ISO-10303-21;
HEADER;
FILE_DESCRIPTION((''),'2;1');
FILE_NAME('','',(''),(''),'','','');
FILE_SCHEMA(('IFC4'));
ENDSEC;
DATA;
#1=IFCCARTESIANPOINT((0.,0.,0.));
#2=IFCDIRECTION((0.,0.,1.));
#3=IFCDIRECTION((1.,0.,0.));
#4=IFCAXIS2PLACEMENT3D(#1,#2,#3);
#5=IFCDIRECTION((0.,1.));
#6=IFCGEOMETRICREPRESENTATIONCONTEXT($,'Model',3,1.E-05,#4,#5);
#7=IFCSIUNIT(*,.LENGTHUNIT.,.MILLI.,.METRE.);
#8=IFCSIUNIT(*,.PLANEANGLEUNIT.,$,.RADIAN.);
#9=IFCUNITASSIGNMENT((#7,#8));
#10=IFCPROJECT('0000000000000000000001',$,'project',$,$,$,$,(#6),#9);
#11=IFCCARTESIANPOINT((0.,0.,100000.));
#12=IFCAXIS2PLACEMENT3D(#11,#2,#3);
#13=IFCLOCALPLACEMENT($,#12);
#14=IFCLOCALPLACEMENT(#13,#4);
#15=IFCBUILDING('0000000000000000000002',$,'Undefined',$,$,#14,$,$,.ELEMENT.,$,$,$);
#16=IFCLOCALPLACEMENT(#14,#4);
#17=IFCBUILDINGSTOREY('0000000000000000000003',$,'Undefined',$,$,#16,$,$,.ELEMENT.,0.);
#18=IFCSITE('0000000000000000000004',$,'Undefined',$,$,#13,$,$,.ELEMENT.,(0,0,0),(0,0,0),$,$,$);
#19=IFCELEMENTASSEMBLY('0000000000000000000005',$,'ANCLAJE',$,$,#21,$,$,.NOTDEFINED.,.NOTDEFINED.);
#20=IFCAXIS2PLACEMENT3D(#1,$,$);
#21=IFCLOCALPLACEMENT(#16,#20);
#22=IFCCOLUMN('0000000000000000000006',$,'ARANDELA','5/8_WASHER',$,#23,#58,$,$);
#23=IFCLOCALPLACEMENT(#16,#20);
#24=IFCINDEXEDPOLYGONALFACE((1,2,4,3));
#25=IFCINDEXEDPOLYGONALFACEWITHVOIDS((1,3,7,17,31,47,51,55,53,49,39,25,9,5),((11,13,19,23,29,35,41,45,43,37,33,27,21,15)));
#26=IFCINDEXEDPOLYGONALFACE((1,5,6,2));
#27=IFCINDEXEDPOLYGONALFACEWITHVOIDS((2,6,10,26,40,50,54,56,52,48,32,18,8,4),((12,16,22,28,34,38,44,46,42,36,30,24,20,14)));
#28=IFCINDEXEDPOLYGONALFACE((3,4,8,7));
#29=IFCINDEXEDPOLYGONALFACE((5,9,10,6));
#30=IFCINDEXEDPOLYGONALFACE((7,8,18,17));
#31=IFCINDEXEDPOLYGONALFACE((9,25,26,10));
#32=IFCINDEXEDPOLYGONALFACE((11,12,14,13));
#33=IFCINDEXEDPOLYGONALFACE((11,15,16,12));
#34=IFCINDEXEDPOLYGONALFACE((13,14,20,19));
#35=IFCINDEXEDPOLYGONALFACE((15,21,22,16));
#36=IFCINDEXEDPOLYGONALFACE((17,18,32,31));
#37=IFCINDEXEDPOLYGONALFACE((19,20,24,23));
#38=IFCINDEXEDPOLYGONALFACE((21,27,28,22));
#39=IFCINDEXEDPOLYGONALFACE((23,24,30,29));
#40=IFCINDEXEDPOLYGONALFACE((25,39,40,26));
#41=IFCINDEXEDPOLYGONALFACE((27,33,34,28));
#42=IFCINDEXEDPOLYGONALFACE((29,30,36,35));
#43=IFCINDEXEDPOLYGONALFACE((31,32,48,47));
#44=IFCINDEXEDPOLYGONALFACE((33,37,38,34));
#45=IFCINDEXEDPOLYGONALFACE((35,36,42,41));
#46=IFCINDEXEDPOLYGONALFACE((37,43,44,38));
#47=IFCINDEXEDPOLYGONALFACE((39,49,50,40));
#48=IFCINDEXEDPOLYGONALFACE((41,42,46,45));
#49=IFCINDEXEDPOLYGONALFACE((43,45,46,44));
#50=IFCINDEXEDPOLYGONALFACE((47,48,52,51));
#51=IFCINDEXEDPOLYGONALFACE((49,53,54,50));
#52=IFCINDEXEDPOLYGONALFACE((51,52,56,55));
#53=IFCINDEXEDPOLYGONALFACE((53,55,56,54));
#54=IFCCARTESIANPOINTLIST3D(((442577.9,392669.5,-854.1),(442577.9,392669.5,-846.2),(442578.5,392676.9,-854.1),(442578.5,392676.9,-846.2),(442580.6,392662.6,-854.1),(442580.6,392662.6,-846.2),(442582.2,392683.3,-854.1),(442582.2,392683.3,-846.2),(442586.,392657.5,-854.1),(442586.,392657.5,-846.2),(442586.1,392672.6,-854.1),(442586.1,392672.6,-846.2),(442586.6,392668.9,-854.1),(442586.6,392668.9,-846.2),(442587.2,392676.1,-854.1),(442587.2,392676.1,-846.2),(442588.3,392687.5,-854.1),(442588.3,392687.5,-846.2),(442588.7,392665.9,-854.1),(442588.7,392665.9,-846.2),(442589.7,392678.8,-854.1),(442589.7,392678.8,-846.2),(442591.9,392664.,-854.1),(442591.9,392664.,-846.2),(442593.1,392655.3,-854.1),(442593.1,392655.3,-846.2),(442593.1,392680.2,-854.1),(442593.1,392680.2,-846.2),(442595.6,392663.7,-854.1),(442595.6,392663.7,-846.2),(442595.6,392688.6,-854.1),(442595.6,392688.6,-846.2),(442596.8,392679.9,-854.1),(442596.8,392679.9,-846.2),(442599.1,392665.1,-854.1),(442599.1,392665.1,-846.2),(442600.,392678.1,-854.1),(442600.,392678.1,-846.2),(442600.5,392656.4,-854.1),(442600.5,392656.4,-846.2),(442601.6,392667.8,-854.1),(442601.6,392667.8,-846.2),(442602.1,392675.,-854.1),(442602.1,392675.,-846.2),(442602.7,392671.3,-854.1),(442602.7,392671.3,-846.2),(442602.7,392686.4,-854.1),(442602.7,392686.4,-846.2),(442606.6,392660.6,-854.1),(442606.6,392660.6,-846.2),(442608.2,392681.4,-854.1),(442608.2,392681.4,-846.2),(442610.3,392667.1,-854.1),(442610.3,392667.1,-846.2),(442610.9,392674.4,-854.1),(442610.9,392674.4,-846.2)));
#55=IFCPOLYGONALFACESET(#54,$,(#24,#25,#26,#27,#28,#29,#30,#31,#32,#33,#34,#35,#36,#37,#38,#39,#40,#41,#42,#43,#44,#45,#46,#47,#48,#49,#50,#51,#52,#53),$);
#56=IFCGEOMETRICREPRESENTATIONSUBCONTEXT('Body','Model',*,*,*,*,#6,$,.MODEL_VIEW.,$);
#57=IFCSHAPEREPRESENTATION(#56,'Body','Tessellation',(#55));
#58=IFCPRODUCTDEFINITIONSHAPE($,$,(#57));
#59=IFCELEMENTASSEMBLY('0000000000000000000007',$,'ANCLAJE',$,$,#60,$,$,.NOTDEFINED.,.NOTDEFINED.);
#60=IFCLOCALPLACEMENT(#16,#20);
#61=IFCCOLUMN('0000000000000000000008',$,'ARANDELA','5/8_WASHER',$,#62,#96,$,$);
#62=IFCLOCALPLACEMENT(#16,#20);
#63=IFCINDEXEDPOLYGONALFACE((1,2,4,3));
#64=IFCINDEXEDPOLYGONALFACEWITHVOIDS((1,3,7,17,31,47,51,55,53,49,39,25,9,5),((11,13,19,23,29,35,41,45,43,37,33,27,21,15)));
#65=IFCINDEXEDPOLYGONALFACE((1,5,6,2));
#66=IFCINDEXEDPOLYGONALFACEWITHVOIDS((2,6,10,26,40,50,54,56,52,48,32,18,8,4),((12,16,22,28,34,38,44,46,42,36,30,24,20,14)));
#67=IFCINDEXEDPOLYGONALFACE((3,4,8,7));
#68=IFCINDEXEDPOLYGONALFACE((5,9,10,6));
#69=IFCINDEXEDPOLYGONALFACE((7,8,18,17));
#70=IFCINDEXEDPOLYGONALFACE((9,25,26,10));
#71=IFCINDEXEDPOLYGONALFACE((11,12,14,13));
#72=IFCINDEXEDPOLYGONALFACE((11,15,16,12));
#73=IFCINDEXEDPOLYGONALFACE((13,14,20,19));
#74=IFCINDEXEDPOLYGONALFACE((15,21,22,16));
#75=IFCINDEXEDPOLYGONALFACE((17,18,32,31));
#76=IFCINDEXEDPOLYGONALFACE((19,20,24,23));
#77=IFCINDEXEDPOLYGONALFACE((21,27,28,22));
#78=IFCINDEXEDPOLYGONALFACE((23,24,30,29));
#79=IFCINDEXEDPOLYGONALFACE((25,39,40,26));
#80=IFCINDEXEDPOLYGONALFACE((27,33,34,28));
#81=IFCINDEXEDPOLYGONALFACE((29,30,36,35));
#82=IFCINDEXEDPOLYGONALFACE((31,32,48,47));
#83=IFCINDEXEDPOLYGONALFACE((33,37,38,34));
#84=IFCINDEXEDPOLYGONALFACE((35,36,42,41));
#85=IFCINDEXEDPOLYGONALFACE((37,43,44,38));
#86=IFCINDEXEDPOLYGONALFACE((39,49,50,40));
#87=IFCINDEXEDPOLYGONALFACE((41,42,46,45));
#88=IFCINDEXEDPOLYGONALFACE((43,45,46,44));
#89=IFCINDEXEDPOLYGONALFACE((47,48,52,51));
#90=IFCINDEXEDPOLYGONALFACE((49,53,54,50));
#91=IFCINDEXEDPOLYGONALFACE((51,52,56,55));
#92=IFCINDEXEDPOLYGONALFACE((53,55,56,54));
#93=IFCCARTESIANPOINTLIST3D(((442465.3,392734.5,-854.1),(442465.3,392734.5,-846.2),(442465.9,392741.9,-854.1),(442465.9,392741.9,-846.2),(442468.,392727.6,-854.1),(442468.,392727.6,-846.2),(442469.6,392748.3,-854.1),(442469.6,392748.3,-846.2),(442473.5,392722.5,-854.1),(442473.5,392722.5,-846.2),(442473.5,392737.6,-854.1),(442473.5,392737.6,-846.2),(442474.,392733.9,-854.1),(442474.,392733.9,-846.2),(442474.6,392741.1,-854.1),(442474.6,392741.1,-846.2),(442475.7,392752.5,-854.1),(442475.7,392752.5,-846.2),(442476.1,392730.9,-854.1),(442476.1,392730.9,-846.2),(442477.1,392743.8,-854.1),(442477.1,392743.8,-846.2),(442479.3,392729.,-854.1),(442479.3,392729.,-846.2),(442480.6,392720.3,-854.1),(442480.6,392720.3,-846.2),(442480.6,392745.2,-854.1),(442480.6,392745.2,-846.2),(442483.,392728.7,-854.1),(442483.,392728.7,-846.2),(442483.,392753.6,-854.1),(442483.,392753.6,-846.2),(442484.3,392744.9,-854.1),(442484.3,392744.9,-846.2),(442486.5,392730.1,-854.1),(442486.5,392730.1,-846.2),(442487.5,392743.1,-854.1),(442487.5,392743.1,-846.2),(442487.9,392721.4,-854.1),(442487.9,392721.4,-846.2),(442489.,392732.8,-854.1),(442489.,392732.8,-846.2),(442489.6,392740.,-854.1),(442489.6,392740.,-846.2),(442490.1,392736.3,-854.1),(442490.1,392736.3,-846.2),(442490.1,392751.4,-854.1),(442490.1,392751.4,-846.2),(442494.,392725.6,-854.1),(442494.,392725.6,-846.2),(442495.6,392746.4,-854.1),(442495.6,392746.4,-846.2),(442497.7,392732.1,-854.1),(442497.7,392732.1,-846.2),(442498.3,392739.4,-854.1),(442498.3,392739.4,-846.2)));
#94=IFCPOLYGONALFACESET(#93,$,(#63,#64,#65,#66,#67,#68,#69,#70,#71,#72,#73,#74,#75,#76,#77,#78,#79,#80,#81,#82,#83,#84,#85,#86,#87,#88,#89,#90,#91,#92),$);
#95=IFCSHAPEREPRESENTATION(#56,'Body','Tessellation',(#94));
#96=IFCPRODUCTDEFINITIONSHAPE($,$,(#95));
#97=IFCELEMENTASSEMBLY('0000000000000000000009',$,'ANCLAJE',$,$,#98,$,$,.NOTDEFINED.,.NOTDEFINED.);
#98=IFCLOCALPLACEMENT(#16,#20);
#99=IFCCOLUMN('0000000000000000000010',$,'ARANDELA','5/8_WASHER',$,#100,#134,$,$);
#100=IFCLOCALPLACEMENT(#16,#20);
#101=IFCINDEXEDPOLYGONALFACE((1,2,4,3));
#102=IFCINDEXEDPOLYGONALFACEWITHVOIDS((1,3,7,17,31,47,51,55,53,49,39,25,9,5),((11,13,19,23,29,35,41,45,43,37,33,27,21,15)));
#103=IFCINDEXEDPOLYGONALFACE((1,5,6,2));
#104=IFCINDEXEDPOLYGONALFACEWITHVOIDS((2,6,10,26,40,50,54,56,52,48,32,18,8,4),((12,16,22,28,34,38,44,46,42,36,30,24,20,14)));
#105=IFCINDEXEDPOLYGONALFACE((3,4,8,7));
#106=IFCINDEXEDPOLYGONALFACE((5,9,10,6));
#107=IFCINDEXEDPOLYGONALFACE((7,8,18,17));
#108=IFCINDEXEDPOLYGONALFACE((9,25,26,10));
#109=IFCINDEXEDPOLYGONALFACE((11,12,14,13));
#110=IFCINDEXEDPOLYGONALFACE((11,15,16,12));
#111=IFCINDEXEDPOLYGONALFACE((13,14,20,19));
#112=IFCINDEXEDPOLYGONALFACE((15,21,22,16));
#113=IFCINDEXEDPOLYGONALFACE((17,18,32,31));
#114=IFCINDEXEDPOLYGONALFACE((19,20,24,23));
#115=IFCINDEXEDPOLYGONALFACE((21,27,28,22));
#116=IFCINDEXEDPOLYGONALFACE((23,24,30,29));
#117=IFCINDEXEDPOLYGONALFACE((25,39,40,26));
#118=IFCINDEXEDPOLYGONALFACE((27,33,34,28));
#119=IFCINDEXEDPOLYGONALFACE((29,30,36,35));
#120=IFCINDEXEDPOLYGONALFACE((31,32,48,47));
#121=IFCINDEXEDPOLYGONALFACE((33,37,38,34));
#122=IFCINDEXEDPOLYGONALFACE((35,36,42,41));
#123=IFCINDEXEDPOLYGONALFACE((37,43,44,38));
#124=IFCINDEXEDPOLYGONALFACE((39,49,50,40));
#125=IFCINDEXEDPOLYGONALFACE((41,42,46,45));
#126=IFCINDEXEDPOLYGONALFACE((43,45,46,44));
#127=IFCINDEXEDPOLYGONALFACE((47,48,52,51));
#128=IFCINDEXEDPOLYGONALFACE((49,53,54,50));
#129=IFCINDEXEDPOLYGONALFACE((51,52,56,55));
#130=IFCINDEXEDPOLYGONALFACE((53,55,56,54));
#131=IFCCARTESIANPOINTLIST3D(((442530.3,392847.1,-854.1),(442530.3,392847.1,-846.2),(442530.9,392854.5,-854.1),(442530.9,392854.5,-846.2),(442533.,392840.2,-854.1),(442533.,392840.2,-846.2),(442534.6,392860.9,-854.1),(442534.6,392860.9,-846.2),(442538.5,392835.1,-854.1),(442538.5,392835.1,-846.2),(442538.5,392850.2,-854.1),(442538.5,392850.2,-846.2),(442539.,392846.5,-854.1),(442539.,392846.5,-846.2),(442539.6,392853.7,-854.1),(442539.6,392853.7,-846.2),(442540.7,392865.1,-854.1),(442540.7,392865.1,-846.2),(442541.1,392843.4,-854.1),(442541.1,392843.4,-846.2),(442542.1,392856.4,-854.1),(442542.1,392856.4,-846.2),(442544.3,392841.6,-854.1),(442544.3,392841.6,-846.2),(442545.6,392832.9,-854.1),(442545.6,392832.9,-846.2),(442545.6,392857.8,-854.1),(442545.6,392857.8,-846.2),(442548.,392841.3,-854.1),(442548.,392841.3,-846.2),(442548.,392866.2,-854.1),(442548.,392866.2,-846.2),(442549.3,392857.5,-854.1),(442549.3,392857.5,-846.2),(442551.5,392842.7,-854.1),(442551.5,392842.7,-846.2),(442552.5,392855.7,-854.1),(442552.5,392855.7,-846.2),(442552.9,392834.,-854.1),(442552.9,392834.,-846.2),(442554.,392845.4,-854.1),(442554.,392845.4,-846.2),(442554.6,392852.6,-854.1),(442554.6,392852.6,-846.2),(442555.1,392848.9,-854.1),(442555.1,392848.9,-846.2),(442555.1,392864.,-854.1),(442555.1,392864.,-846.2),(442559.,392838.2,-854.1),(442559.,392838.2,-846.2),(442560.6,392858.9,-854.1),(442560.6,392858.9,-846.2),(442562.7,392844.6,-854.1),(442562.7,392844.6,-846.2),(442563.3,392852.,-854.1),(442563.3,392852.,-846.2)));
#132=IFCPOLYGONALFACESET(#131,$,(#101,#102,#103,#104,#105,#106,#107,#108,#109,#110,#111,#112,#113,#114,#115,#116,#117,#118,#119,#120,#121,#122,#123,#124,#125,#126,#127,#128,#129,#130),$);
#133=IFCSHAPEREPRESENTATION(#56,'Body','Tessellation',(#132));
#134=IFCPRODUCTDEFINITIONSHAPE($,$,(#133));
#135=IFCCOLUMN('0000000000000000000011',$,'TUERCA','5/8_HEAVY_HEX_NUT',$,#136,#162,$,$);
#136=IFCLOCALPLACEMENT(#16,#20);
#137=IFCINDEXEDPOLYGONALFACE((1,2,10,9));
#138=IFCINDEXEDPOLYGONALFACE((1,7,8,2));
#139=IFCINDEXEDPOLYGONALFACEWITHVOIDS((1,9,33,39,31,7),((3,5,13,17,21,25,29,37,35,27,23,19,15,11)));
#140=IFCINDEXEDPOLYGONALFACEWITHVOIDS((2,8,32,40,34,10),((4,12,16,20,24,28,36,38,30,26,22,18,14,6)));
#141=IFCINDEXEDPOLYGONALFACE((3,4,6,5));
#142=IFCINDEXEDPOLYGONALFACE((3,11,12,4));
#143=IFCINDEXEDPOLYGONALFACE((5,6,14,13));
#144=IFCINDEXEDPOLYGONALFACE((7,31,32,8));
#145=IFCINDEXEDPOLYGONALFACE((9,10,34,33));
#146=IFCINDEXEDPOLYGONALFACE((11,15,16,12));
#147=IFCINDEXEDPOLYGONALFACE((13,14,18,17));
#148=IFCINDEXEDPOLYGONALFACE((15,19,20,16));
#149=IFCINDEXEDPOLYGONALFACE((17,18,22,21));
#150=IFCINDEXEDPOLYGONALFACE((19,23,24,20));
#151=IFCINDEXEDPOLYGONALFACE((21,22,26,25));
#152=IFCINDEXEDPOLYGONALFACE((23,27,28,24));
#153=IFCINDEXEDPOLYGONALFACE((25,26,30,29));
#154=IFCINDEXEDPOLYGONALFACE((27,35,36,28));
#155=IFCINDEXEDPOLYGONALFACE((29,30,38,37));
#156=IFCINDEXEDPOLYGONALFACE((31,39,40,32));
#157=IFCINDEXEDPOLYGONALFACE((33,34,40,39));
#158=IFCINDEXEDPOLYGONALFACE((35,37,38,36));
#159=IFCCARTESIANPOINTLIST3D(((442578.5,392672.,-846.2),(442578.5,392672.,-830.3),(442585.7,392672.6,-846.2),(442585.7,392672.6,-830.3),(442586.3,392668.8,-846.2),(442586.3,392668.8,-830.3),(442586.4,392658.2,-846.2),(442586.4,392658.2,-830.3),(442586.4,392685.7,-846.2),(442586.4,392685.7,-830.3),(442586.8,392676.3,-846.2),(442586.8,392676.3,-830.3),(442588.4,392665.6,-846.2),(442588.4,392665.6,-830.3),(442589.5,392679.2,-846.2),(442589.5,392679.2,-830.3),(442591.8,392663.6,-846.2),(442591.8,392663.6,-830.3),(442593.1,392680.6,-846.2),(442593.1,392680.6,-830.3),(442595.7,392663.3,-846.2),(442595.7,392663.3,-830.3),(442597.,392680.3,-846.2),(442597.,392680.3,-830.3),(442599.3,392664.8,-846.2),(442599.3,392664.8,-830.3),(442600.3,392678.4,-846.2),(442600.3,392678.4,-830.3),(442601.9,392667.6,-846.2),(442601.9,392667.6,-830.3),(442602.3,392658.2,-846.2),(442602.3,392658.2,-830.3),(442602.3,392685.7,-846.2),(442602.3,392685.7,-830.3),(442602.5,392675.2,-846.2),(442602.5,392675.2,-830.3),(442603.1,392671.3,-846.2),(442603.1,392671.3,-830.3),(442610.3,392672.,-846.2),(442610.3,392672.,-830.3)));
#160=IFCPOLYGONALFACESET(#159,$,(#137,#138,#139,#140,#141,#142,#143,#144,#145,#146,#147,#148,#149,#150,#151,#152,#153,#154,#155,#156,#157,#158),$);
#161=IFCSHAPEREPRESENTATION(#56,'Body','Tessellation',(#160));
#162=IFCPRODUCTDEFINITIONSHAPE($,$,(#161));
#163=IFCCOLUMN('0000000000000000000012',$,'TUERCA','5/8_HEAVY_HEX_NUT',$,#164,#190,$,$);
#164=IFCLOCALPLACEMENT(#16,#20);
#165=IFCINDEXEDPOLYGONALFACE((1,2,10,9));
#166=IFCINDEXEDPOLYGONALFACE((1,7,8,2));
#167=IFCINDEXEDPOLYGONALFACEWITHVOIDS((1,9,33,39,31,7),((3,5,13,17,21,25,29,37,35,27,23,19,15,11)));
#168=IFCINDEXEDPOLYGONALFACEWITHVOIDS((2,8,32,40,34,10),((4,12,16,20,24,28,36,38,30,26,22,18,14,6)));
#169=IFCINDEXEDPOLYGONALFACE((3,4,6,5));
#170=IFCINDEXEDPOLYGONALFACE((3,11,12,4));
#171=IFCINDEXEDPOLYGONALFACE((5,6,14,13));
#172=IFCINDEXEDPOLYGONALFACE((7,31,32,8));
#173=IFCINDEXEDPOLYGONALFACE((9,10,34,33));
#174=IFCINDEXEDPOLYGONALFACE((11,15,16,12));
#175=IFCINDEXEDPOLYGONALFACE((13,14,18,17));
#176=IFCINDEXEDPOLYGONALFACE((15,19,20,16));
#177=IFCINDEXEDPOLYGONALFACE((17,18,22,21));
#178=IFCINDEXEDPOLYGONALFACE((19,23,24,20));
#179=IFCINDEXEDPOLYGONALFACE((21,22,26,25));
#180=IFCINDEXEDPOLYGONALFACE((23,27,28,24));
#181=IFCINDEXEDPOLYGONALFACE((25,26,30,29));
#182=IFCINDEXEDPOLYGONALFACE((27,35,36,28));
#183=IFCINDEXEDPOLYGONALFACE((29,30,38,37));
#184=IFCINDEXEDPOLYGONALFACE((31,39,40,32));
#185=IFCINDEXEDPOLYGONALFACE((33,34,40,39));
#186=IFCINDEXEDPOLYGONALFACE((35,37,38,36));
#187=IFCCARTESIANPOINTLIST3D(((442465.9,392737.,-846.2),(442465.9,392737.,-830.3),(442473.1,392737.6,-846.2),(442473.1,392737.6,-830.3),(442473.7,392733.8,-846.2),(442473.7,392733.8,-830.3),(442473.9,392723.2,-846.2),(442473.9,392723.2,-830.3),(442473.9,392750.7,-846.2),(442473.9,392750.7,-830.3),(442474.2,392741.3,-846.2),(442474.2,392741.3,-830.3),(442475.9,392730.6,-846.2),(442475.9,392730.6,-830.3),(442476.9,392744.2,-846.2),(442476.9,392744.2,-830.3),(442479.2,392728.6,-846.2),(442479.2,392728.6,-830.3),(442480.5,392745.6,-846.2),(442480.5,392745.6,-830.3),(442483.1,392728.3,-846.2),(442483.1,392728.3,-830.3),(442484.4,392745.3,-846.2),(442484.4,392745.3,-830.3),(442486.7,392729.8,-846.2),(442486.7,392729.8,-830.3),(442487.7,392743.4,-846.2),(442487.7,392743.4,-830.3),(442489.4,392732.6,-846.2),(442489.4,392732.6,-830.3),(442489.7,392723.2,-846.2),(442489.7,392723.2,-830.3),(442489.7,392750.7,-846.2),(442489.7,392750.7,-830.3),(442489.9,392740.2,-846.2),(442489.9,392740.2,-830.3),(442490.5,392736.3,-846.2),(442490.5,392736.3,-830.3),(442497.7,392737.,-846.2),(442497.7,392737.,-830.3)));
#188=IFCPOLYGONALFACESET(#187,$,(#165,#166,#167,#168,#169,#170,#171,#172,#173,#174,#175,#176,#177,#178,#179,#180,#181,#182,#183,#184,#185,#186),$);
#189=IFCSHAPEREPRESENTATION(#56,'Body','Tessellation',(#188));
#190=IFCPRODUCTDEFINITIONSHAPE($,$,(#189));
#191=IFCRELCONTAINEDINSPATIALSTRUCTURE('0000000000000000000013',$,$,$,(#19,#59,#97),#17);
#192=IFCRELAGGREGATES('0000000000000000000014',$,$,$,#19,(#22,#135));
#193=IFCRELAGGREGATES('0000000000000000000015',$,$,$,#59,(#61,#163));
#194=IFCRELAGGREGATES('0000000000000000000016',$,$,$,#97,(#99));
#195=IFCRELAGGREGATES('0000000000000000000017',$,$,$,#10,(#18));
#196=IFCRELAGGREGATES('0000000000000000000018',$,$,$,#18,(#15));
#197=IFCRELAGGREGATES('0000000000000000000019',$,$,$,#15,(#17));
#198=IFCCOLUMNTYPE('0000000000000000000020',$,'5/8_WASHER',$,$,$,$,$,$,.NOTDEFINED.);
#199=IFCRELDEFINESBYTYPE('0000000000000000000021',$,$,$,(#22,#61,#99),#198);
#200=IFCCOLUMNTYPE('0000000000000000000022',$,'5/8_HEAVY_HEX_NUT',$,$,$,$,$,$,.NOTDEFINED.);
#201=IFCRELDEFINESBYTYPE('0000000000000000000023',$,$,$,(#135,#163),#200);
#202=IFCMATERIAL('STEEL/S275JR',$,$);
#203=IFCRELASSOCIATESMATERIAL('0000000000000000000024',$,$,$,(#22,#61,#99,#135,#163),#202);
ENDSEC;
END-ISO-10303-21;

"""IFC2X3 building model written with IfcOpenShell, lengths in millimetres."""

from ifc_helpers import new_model, si_unit, direction, frame, origin_with_axes, place, context, subcontext, project, spatial, polyline, outline, extrude, material, type_object, element, aggregate, save


model = new_model("IFC2X3")

# Units and contexts
model_context = context("Model", 3, precision=1e-05, world=origin_with_axes(), true_north=direction((0.0, 1.0)))
body_context = subcontext(model_context, "Body", "Model", "MODEL_VIEW")
ifc_project = project(units=[si_unit("LENGTHUNIT", "METRE", prefix="MILLI"), si_unit("PLANEANGLEUNIT", "RADIAN")], contexts=[model_context])

# Site, building, storey
site_placement = place(None, frame((0.0, 0.0, 100000.0), z_axis=(0.0, 0.0, 1.0), x_axis=(1.0, 0.0, 0.0)))
site = spatial("IfcSite", under=ifc_project, at=site_placement, Name="Undefined", CompositionType="ELEMENT", RefLatitude=(0, 0, 0), RefLongitude=(0, 0, 0))
building_placement = place(site_placement, origin_with_axes())
building = spatial("IfcBuilding", under=site, at=building_placement, Name="Undefined", CompositionType="ELEMENT")
storey_placement = place(building_placement, origin_with_axes())
storey = spatial("IfcBuildingStorey", under=building, at=storey_placement, Name="Undefined", CompositionType="ELEMENT", Elevation=0.0)

# Element assemblies, columns
assembly_1_placement = place(storey_placement, origin_with_axes())
assembly_1 = element("IfcElementAssembly", 1, at=assembly_1_placement, inside=storey, Name="ANCLAJE", AssemblyPlace="NOTDEFINED", PredefinedType="NOTDEFINED")
ifc_material_1 = material(Name="STEEL/S275JR")
column_type_1 = type_object("IfcColumnType", Name="5/8_WASHER", PredefinedType="NOTDEFINED")
column_1_placement = place(assembly_1_placement, frame((442594.4, 392672.0, -846.2), z_axis=(0.0, 0.0, -1.0), x_axis=(0.866025, -0.5, 0.0)))
column_1 = element("IfcColumn", 2, at=column_1_placement, type_object=column_type_1, material=ifc_material_1, Name="ARANDELA", Description="5/8_WASHER", context=body_context, shape_type="SweptSolid", body=[
    extrude(outline(polyline([(10.4, 13.0), (15.0, 7.2), (16.7, 0.0), (15.0, -7.2), (10.4, -13.0), (3.7, -16.3), (-3.7, -16.3), (-10.4, -13.0), (-15.0, -7.2), (-16.7, 0.0), (-15.0, 7.2), (-10.4, 13.0), (-3.7, 16.3), (3.7, 16.3), (10.4, 13.0)]), holes=[polyline([(6.5, -5.2), (8.1, -1.9), (8.1, 1.9), (6.5, 5.2), (3.6, 7.5), (0.0, 8.3), (-3.6, 7.5), (-6.5, 5.2), (-8.1, 1.9), (-8.1, -1.9), (-6.5, -5.2), (-3.6, -7.5), (0.0, -8.3), (3.6, -7.5), (6.5, -5.2)])]), frame((0.0, 0.0, 7.9), z_axis=(0.0, 0.0, -1.0), x_axis=(0.0, 1.0, 0.0)), (0.0, 0.0, 1.0), 7.9),
])
assembly_2_placement = place(storey_placement, origin_with_axes())
assembly_2 = element("IfcElementAssembly", 3, at=assembly_2_placement, inside=storey, Name="ANCLAJE", AssemblyPlace="NOTDEFINED", PredefinedType="NOTDEFINED")
column_2_placement = place(assembly_2_placement, frame((442481.8, 392737.0, -846.2), z_axis=(0.0, 0.0, -1.0), x_axis=(0.866025, -0.5, 0.0)))
column_2 = element("IfcColumn", 4, at=column_2_placement, type_object=column_type_1, material=ifc_material_1, Name="ARANDELA", Description="5/8_WASHER", context=body_context, shape_type="SweptSolid", body=[
    extrude(outline(polyline([(10.4, 13.0), (15.0, 7.2), (16.7, 0.0), (15.0, -7.2), (10.4, -13.0), (3.7, -16.3), (-3.7, -16.3), (-10.4, -13.0), (-15.0, -7.2), (-16.7, 0.0), (-15.0, 7.2), (-10.4, 13.0), (-3.7, 16.3), (3.7, 16.3), (10.4, 13.0)]), holes=[polyline([(6.5, -5.2), (8.1, -1.9), (8.1, 1.9), (6.5, 5.2), (3.6, 7.5), (0.0, 8.3), (-3.6, 7.5), (-6.5, 5.2), (-8.1, 1.9), (-8.1, -1.9), (-6.5, -5.2), (-3.6, -7.5), (0.0, -8.3), (3.6, -7.5), (6.5, -5.2)])]), frame((0.0, 0.0, 7.9), z_axis=(0.0, 0.0, -1.0), x_axis=(0.0, 1.0, 0.0)), (0.0, 0.0, 1.0), 7.9),
])
assembly_3_placement = place(storey_placement, origin_with_axes())
assembly_3 = element("IfcElementAssembly", 5, at=assembly_3_placement, inside=storey, Name="ANCLAJE", AssemblyPlace="NOTDEFINED", PredefinedType="NOTDEFINED")
column_3_placement = place(assembly_3_placement, frame((442546.8, 392849.5, -846.2), z_axis=(0.0, 0.0, -1.0), x_axis=(-0.866025, 0.5, 0.0)))
column_3 = element("IfcColumn", 6, at=column_3_placement, type_object=column_type_1, material=ifc_material_1, Name="ARANDELA", Description="5/8_WASHER", context=body_context, shape_type="SweptSolid", body=[
    extrude(outline(polyline([(10.4, 13.0), (15.0, 7.2), (16.7, 0.0), (15.0, -7.2), (10.4, -13.0), (3.7, -16.3), (-3.7, -16.3), (-10.4, -13.0), (-15.0, -7.2), (-16.7, 0.0), (-15.0, 7.2), (-10.4, 13.0), (-3.7, 16.3), (3.7, 16.3), (10.4, 13.0)]), holes=[polyline([(6.5, -5.2), (8.1, -1.9), (8.1, 1.9), (6.5, 5.2), (3.6, 7.5), (0.0, 8.3), (-3.6, 7.5), (-6.5, 5.2), (-8.1, 1.9), (-8.1, -1.9), (-6.5, -5.2), (-3.6, -7.5), (0.0, -8.3), (3.6, -7.5), (6.5, -5.2)])]), frame((0.0, 0.0, 7.9), z_axis=(0.0, 0.0, -1.0), x_axis=(0.0, 1.0, 0.0)), (0.0, 0.0, 1.0), 7.9),
])

# Columns
column_type_2 = type_object("IfcColumnType", Name="5/8_HEAVY_HEX_NUT", PredefinedType="NOTDEFINED")
column_4_placement = place(assembly_1_placement, frame((442594.4, 392672.0, -830.3), z_axis=(0.0, 0.0, -1.0), x_axis=(0.866025, -0.5, 0.0)))
column_4 = element("IfcColumn", 7, at=column_4_placement, type_object=column_type_2, material=ifc_material_1, Name="TUERCA", Description="5/8_HEAVY_HEX_NUT", context=body_context, shape_type="SweptSolid", body=[
    extrude(outline(polyline([(-7.9, -13.7), (-15.9, 0.0), (-7.9, 13.7), (7.9, 13.7), (15.9, 0.0), (7.9, -13.7), (-7.9, -13.7)]), holes=[polyline([(3.8, 7.9), (0.0, 8.7), (-3.8, 7.9), (-6.8, 5.4), (-8.5, 1.9), (-8.5, -1.9), (-6.8, -5.4), (-3.8, -7.9), (0.0, -8.7), (3.8, -7.9), (6.8, -5.4), (8.5, -1.9), (8.5, 1.9), (6.8, 5.4), (3.8, 7.9)])]), frame((0.0, 0.0, 15.9), z_axis=(0.0, 0.0, -1.0), x_axis=(0.0, 1.0, 0.0)), (0.0, 0.0, 1.0), 15.9),
])
column_5_placement = place(assembly_2_placement, frame((442481.8, 392737.0, -830.3), z_axis=(0.0, 0.0, -1.0), x_axis=(0.866025, -0.5, 0.0)))
column_5 = element("IfcColumn", 8, at=column_5_placement, type_object=column_type_2, material=ifc_material_1, Name="TUERCA", Description="5/8_HEAVY_HEX_NUT", context=body_context, shape_type="SweptSolid", body=[
    extrude(outline(polyline([(-7.9, -13.7), (-15.9, 0.0), (-7.9, 13.7), (7.9, 13.7), (15.9, 0.0), (7.9, -13.7), (-7.9, -13.7)]), holes=[polyline([(3.8, 7.9), (0.0, 8.7), (-3.8, 7.9), (-6.8, 5.4), (-8.5, 1.9), (-8.5, -1.9), (-6.8, -5.4), (-3.8, -7.9), (0.0, -8.7), (3.8, -7.9), (6.8, -5.4), (8.5, -1.9), (8.5, 1.9), (6.8, 5.4), (3.8, 7.9)])]), frame((0.0, 0.0, 15.9), z_axis=(0.0, 0.0, -1.0), x_axis=(0.0, 1.0, 0.0)), (0.0, 0.0, 1.0), 15.9),
])
aggregate(assembly_1, [column_1, column_4])
aggregate(assembly_2, [column_2, column_5])
aggregate(assembly_3, [column_3])

save(model, "model.ifc")
